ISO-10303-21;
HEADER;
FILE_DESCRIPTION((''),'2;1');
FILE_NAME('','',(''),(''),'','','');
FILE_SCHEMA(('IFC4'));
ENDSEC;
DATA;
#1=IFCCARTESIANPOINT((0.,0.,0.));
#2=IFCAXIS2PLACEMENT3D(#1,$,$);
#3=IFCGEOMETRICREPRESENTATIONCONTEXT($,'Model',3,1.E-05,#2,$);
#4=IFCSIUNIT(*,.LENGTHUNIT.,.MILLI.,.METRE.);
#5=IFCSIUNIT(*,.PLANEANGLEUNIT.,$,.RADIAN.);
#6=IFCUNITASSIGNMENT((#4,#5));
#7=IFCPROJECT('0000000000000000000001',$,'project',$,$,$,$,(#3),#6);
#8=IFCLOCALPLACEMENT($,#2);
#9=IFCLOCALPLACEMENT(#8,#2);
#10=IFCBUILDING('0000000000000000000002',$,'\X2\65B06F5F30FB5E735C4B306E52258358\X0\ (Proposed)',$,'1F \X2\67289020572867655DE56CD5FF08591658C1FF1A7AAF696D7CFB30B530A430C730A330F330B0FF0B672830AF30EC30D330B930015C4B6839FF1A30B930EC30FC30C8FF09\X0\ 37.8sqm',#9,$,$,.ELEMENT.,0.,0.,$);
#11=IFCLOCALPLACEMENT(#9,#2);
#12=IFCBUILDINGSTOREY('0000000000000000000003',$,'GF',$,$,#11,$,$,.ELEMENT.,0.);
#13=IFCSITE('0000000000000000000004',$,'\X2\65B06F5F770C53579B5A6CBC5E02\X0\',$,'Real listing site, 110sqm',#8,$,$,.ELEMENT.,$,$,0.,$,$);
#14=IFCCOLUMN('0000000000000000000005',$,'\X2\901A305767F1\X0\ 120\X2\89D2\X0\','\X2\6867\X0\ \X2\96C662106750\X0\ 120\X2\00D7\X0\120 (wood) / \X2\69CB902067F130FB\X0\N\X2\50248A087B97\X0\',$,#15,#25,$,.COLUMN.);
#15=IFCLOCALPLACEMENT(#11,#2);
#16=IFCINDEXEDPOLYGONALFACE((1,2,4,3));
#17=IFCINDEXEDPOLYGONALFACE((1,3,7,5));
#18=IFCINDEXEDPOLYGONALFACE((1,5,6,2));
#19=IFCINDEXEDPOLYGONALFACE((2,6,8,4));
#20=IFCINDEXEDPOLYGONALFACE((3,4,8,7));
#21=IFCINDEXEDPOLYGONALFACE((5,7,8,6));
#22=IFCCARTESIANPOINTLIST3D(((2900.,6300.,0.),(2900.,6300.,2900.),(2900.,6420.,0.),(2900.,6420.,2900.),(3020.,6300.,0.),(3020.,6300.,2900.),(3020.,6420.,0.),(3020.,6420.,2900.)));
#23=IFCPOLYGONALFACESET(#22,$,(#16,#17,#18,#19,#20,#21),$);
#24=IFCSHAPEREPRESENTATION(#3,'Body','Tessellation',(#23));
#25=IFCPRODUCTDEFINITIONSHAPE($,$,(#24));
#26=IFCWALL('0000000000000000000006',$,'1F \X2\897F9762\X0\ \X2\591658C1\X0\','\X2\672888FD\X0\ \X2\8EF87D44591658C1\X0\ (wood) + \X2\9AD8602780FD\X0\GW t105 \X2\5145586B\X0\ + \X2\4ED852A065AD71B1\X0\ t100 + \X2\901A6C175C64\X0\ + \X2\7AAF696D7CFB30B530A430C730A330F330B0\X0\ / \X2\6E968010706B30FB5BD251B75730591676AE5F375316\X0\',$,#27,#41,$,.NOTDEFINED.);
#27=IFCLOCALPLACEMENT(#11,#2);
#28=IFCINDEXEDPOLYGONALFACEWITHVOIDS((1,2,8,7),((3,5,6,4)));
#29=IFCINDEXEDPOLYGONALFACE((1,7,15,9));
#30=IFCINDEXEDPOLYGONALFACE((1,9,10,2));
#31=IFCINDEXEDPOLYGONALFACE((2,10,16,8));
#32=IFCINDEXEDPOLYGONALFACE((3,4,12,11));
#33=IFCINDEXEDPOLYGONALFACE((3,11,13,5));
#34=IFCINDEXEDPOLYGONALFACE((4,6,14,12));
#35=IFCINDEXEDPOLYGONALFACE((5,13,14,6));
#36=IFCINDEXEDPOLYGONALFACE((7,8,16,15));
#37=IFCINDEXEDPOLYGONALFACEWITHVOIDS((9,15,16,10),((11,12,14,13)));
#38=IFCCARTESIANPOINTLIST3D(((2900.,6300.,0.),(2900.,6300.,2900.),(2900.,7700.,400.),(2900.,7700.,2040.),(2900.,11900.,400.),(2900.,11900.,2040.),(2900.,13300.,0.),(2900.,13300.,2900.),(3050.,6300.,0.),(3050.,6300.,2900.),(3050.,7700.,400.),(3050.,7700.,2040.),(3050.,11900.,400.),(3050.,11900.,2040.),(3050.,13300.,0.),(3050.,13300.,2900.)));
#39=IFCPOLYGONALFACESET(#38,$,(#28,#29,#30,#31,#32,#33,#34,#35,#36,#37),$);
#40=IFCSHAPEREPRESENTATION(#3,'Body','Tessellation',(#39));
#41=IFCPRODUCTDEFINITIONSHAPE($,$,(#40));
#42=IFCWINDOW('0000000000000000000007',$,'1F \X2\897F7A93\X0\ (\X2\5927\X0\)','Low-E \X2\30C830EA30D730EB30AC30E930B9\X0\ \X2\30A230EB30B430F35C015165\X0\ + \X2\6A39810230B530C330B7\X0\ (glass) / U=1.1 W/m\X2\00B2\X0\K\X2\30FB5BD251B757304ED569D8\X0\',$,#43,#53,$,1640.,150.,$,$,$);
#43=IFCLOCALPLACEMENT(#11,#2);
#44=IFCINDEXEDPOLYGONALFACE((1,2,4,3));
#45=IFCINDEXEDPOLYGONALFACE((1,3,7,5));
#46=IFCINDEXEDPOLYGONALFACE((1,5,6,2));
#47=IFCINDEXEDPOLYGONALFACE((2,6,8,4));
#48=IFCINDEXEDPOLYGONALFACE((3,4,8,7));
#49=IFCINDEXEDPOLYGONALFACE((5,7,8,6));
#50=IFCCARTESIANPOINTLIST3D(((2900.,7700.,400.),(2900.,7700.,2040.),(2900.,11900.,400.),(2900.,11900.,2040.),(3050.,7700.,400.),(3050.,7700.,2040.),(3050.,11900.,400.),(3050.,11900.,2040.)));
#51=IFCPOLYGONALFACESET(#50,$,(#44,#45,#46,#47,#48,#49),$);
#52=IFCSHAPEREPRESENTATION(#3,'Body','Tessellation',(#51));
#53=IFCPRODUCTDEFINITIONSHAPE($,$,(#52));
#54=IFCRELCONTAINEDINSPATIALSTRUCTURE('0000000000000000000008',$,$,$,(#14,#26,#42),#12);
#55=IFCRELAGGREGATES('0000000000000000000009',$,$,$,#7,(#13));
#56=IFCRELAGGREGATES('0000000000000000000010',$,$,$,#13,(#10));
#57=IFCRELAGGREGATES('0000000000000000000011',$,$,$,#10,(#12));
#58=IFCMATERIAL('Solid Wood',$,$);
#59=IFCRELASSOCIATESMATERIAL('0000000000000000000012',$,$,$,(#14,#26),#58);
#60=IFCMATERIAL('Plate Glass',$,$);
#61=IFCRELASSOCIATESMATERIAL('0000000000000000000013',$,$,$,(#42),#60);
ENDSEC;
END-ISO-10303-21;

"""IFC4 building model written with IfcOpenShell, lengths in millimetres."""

from ifc_helpers import new_model, si_unit, frame, frame_2d, origin, place, context, project, spatial, rectangle, extrude, material, element, fill, save


model = new_model("IFC4")

# Units and contexts
model_context = context("Model", 3, precision=1e-05, world=origin())
ifc_project = project(units=[si_unit("LENGTHUNIT", "METRE", prefix="MILLI"), si_unit("PLANEANGLEUNIT", "RADIAN")], contexts=[model_context])

# Site, building, storey
site_placement = place(None, origin())
site = spatial("IfcSite", under=ifc_project, at=site_placement, Name="新潟県南魚沼市", ObjectType="Real listing site, 110sqm", CompositionType="ELEMENT", RefElevation=0.0)
building_placement = place(site_placement, origin())
building = spatial("IfcBuilding", under=site, at=building_placement, Name="新潟・平屋の別荘 (Proposed)", ObjectType="1F 木造在来工法（外壁：窯業系サイディング＋木クレビス、屋根：スレート） 37.8sqm", CompositionType="ELEMENT", ElevationOfRefHeight=0.0, ElevationOfTerrain=0.0)
storey_placement = place(building_placement, origin())
storey = spatial("IfcBuildingStorey", under=building, at=storey_placement, Name="GF", CompositionType="ELEMENT", Elevation=0.0)

# Column
ifc_material_1 = material(Name="Solid Wood")
column_1_placement = place(storey_placement, frame((1450.0, 3150.0, 0.0)))
element("IfcColumn", 1, at=column_1_placement, inside=storey, material=ifc_material_1, Name="通し柱 120角", Description="桧 集成材 120×120 (wood) / 構造柱・N値計算", PredefinedType="COLUMN", context=model_context, shape_type="SweptSolid", body=[
    extrude(rectangle(XDim=120.0, YDim=120.0, at=frame_2d((60.0, 60.0))), frame((1450.0, 3150.0, 0.0)), (0.0, 0.0, 1.0), 2900.0),
])

# Shared definitions
ifc_material_2 = material(Name="Plate Glass")

# Wall, opening, window
wall_1_placement = place(storey_placement, frame((1450.0, 3150.0, 0.0)))
wall_1 = element("IfcWall", 2, at=wall_1_placement, inside=storey, material=ifc_material_1, Name="1F 西面 外壁", Description="木製 軸組外壁 (wood) + 高性能GW t105 充填 + 付加断熱 t100 + 通気層 + 窯業系サイディング / 準耐火・寒冷地外皮強化", PredefinedType="NOTDEFINED", context=model_context, shape_type="SweptSolid", body=[
    extrude(rectangle(XDim=150.0, YDim=7000.0, at=frame_2d((75.0, 3500.0))), frame((1450.0, 3150.0, 0.0)), (0.0, 0.0, 1.0), 2900.0),
])
opening_1_placement = place(storey_placement, frame((1450.0, 3850.0, 200.0)))
opening_1 = element("IfcOpeningElement", 3, at=opening_1_placement, cuts=wall_1, PredefinedType="NOTDEFINED", context=model_context, shape_type="SweptSolid", body=[
    extrude(rectangle(XDim=150.0, YDim=4200.0, at=frame_2d((75.0, 2100.0))), frame((1450.0, 3850.0, 200.0)), (0.0, 0.0, 1.0), 1640.0),
])
window_1_placement = place(storey_placement, frame((1450.0, 3850.0, 200.0)))
window_1 = element("IfcWindow", 4, at=window_1_placement, inside=storey, material=ifc_material_2, Name="1F 西窓 (大)", Description="Low-E トリプルガラス アルゴン封入 + 樹脂サッシ (glass) / U=1.1 W/m²K・寒冷地仕様", OverallHeight=1640.0, OverallWidth=150.0, context=model_context, shape_type="SweptSolid", body=[
    extrude(rectangle(XDim=150.0, YDim=4200.0, at=frame_2d((75.0, 2100.0))), frame((1450.0, 3850.0, 200.0)), (0.0, 0.0, 1.0), 1640.0),
])
fill(opening_1, window_1)

save(model, "model.ifc")
